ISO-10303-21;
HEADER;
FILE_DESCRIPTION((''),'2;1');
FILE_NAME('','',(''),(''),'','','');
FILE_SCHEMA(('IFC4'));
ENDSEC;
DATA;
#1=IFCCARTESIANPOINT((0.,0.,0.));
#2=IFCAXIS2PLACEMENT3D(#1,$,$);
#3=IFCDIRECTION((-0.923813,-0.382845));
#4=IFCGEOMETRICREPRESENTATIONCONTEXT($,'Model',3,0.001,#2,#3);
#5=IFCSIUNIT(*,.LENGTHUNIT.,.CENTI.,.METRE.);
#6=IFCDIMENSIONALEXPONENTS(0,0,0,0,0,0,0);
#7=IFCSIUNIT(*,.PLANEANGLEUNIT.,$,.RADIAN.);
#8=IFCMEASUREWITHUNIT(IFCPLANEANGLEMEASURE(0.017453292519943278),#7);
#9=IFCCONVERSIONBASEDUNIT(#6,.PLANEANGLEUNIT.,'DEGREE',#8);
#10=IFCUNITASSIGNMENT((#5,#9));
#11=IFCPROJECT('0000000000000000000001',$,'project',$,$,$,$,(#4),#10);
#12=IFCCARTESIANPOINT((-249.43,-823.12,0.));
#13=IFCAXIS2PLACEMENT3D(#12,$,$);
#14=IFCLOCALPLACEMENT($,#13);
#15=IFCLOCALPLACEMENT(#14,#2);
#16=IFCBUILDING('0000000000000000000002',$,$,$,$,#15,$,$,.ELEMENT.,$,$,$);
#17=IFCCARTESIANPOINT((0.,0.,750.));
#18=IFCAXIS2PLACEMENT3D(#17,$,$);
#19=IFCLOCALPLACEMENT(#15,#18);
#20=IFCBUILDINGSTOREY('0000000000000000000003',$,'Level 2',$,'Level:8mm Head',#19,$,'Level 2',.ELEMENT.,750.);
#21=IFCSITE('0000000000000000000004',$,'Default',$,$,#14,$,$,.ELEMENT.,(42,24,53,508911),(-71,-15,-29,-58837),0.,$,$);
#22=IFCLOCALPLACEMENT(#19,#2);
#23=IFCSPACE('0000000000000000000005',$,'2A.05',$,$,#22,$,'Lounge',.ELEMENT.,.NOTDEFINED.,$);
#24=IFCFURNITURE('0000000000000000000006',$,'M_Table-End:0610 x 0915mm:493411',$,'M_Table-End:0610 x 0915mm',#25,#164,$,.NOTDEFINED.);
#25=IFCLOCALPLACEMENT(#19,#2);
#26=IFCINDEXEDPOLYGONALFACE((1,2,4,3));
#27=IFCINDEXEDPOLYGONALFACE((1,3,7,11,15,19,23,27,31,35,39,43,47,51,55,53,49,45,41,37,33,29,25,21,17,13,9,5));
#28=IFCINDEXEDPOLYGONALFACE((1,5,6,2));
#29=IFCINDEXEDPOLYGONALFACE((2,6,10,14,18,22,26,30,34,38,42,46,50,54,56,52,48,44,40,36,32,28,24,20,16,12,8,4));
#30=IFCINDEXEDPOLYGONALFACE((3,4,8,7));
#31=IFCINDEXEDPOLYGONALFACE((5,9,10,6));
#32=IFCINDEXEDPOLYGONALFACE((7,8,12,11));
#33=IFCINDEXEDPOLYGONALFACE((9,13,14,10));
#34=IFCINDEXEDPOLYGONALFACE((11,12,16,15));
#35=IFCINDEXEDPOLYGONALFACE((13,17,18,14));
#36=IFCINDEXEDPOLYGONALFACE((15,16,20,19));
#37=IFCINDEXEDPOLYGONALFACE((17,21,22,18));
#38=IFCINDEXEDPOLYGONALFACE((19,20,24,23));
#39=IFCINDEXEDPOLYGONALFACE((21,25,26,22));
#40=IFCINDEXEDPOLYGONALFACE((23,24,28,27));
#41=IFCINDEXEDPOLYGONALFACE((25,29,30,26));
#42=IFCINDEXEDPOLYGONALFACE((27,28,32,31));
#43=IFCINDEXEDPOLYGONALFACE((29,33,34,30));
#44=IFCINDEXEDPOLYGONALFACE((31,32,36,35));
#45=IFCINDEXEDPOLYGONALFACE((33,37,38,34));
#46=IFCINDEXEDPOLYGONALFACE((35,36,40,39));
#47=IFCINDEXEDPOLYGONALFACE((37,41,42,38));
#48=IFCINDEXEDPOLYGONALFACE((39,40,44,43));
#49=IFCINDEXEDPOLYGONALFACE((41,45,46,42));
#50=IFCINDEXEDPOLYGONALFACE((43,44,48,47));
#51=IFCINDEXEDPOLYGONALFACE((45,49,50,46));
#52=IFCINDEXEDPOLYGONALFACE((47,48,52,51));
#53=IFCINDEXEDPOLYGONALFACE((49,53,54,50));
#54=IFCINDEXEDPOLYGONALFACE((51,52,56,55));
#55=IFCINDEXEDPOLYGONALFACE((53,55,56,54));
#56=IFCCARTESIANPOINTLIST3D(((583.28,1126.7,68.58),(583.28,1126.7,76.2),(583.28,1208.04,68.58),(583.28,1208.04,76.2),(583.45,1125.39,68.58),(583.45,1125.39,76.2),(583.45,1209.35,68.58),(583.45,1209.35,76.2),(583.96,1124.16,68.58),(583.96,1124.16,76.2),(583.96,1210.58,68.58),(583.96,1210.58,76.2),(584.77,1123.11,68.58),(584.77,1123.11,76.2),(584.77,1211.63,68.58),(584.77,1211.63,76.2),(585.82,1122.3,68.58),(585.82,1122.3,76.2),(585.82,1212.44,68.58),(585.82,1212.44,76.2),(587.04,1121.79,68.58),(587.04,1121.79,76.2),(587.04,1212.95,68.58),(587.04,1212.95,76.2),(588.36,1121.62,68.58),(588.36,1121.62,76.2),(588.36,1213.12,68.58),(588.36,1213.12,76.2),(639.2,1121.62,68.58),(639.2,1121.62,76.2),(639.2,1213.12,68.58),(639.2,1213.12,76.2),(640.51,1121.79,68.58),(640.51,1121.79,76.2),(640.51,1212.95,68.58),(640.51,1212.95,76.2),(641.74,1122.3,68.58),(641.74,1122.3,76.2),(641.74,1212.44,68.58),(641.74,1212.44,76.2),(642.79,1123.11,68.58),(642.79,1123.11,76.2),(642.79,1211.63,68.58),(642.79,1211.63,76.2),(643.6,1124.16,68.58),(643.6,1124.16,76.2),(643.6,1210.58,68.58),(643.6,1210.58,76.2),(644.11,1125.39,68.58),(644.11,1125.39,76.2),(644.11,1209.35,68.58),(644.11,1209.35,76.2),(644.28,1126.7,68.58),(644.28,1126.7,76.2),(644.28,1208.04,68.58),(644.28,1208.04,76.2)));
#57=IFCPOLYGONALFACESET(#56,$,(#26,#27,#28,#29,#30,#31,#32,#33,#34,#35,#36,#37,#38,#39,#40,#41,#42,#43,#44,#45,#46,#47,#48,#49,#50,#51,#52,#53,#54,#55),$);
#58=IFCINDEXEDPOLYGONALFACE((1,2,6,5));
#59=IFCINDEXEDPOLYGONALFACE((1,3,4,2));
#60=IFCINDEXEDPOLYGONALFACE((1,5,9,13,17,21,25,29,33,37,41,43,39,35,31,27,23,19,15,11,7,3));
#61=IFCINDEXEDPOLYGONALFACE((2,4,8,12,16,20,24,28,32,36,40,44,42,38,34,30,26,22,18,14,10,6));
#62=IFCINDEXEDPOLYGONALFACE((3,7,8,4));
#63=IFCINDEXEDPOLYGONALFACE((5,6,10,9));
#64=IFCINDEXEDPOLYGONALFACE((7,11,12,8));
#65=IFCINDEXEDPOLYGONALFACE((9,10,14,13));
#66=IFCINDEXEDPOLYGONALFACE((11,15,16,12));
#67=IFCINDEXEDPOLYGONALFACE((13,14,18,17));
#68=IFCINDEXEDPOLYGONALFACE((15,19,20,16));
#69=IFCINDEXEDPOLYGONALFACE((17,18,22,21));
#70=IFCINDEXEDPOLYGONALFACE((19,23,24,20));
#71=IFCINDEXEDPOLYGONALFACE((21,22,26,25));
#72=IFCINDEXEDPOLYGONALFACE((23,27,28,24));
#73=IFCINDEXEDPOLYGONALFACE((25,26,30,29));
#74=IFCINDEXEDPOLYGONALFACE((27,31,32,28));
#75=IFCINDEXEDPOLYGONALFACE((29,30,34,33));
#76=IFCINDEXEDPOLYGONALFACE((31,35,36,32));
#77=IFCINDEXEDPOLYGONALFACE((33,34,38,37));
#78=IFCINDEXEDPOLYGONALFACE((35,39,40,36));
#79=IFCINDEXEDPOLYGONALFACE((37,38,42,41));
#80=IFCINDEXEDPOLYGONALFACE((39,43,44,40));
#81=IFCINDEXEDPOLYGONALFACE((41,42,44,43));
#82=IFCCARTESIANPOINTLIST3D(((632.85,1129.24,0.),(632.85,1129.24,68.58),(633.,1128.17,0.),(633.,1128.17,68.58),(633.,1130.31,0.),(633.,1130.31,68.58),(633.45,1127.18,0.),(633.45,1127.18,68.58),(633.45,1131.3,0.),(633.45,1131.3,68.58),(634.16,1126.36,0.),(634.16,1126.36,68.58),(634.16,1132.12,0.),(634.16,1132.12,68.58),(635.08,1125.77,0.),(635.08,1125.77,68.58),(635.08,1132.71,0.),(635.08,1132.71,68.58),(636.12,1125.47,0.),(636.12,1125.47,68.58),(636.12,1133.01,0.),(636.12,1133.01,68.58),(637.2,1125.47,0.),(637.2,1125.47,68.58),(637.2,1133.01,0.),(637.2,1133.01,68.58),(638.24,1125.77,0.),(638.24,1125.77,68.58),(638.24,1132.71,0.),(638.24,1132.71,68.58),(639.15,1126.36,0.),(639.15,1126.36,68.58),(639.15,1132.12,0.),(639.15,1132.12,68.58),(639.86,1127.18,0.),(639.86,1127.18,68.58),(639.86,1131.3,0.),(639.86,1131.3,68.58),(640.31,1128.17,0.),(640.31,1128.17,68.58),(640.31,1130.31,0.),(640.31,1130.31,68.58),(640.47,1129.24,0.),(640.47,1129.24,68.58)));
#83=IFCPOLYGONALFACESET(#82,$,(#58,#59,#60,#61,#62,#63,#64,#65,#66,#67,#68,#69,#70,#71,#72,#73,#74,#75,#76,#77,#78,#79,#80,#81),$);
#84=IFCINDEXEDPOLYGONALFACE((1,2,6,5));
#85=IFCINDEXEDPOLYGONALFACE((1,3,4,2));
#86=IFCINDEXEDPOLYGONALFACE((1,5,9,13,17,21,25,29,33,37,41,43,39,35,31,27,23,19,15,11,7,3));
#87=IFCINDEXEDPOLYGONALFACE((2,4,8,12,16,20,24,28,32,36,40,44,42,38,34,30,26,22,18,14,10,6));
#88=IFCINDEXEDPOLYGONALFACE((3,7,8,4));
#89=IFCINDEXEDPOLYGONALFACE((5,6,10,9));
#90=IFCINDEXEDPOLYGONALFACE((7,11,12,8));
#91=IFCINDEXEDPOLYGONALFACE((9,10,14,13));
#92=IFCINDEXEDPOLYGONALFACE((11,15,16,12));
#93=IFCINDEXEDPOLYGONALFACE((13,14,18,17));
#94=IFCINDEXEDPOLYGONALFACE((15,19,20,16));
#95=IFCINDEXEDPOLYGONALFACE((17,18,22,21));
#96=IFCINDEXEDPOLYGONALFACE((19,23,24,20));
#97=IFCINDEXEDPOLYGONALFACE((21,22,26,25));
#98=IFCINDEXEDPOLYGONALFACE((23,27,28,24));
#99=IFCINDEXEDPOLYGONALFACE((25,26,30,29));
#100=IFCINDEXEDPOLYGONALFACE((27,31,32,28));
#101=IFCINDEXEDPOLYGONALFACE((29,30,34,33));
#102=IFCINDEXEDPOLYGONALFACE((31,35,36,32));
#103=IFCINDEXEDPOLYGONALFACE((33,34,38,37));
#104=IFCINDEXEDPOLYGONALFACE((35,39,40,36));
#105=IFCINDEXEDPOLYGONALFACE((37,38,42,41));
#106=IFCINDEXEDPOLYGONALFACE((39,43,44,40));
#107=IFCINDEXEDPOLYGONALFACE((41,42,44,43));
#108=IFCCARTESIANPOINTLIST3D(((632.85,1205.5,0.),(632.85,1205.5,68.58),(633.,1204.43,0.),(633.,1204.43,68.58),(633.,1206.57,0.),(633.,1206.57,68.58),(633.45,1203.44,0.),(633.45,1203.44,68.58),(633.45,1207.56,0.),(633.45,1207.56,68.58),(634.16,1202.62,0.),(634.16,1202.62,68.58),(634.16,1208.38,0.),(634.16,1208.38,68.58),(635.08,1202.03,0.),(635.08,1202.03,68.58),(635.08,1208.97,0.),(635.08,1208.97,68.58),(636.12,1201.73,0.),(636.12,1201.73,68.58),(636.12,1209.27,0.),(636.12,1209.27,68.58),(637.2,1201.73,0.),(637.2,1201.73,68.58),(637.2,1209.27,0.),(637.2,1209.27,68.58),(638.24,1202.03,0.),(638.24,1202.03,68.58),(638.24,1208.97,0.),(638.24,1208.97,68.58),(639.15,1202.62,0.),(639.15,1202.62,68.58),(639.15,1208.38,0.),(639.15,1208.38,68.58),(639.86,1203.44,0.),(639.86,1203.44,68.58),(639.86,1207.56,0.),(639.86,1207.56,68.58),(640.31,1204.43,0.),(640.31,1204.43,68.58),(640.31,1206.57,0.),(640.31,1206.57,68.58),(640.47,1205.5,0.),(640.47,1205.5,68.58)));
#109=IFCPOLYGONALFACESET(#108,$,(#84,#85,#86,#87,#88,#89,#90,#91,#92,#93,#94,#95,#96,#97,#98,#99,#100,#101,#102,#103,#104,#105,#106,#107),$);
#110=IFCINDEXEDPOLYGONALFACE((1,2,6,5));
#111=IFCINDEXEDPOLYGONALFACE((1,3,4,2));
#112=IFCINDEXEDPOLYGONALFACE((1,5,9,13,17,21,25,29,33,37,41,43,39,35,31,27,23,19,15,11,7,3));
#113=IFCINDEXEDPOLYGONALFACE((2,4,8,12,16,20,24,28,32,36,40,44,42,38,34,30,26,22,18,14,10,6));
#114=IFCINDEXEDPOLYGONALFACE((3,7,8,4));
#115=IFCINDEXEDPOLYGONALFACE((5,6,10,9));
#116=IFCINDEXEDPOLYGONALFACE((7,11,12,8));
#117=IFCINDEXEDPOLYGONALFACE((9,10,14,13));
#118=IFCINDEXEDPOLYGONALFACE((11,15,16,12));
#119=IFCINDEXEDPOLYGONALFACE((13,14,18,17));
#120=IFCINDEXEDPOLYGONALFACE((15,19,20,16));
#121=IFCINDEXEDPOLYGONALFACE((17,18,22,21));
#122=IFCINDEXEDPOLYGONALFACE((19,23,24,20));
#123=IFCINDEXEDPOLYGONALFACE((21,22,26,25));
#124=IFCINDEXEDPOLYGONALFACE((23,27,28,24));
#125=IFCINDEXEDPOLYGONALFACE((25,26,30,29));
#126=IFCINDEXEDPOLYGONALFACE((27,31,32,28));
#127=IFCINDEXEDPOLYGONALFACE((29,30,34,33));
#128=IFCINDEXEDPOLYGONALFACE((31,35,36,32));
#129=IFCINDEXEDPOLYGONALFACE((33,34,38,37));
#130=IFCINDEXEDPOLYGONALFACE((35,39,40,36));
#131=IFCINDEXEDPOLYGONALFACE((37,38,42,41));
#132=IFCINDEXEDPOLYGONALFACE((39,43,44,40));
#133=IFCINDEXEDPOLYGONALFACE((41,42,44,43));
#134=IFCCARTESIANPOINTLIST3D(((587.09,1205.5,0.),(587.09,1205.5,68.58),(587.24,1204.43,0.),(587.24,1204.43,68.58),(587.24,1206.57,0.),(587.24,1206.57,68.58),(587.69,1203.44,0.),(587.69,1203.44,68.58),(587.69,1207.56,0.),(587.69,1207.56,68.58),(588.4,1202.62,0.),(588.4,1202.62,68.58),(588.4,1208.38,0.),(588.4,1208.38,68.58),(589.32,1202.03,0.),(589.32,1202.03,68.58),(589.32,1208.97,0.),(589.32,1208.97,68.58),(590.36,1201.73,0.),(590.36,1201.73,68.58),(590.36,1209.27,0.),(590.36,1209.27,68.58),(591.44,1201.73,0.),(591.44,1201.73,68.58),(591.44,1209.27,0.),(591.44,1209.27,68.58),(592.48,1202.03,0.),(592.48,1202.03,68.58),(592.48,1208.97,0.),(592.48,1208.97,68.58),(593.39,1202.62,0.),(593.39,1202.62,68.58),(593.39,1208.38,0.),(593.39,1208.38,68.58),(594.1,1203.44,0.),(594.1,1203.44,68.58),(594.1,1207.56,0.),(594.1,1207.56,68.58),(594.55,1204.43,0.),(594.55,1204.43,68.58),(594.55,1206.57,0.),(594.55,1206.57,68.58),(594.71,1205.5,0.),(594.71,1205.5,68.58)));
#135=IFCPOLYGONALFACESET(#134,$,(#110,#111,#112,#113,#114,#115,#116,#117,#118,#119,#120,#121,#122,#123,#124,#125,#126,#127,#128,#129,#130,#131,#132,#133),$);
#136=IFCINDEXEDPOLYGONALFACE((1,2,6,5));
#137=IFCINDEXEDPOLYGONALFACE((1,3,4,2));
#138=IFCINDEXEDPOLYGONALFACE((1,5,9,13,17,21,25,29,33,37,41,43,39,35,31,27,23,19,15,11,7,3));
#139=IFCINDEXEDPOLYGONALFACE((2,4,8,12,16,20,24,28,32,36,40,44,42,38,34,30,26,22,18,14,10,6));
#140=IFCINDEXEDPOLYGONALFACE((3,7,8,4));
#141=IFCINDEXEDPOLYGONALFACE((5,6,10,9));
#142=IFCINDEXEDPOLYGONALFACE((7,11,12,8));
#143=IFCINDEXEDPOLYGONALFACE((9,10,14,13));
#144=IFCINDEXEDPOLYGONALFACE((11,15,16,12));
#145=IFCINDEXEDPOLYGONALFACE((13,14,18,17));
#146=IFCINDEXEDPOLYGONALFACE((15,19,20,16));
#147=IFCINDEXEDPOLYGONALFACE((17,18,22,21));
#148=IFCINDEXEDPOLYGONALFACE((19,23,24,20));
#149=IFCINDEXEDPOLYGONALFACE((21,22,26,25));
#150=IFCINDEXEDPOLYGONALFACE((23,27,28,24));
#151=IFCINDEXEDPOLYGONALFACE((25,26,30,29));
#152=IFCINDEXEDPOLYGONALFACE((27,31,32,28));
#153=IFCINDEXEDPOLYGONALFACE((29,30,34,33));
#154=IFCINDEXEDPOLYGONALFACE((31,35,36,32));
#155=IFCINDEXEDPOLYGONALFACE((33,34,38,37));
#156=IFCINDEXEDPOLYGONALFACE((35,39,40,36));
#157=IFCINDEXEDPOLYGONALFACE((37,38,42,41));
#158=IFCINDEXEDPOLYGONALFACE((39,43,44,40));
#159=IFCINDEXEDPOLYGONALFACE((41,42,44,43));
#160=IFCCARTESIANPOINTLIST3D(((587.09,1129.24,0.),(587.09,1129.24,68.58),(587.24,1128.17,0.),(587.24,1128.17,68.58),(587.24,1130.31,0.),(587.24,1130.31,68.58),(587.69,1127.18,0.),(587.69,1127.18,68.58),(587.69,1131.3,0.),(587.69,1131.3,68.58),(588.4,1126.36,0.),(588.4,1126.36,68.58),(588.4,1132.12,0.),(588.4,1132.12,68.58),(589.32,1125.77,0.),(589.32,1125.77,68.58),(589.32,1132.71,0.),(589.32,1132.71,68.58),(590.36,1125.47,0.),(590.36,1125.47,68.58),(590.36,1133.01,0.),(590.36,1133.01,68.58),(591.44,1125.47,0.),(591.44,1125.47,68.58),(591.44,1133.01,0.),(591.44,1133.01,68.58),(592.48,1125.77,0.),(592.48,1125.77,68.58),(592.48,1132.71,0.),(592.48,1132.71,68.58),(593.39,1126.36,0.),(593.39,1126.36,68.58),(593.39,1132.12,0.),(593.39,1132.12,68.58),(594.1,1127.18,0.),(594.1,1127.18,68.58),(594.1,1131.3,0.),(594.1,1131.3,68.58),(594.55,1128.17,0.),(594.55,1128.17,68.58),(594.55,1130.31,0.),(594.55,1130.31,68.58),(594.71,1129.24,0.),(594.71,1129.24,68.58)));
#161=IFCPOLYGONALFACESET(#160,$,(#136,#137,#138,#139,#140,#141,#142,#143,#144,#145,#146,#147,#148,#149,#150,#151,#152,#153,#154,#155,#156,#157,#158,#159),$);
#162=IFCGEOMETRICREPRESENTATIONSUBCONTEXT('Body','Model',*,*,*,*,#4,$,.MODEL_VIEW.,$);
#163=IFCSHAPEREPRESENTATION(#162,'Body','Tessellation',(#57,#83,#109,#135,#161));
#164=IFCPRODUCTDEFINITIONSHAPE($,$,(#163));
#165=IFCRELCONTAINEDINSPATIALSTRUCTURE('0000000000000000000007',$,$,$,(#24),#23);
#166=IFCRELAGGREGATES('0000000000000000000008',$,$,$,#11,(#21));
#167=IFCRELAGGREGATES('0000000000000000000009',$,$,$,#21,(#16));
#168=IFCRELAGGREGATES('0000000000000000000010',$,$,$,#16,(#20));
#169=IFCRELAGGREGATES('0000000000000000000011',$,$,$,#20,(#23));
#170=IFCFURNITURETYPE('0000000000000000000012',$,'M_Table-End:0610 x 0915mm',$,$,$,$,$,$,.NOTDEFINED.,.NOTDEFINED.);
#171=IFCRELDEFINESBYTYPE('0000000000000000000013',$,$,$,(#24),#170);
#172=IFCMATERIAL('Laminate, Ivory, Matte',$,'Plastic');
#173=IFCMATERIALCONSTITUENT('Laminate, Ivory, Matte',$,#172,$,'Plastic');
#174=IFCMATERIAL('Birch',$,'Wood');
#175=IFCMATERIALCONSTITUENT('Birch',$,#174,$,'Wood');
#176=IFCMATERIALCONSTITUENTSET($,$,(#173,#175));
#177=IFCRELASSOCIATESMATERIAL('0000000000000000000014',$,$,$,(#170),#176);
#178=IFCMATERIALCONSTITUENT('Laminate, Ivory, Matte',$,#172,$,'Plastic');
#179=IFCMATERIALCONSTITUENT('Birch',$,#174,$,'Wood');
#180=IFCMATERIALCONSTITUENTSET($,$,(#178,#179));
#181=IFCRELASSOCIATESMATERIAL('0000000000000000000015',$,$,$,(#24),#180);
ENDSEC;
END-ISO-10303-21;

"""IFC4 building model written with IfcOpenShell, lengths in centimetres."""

from ifc_helpers import new_model, entity, si_unit, converted_unit, direction, frame, origin, place, context, subcontext, project, spatial, line, arc, indexed_curve, outline, extrude, source, transform, mapped, material, constituent, constituent_set, type_object, type_shapes, element, save


model = new_model("IFC4")

# Units and contexts
model_context = context("Model", 3, precision=0.001, world=origin(), true_north=direction((-0.923813, -0.382845)))
body_context = subcontext(model_context, "Body", "Model", "MODEL_VIEW")
ifc_project = project(units=[si_unit("LENGTHUNIT", "METRE", prefix="CENTI"), converted_unit("PLANEANGLEUNIT", "DEGREE", entity("IfcPlaneAngleMeasure", 0.017453292519943278), si_unit("PLANEANGLEUNIT", "RADIAN"), dimensions=[0, 0, 0, 0, 0, 0, 0])], contexts=[model_context])

# Site, building, storey
site_placement = place(None, frame((-249.43, -823.12, 0.0)))
site = spatial("IfcSite", under=ifc_project, at=site_placement, Name="Default", CompositionType="ELEMENT", RefLatitude=(42, 24, 53, 508911), RefLongitude=(-71, -15, -29, -58837), RefElevation=0.0)
building_placement = place(site_placement, origin())
building = spatial("IfcBuilding", under=site, at=building_placement, CompositionType="ELEMENT")
storey_placement = place(building_placement, frame((0.0, 0.0, 750.0)))
storey = spatial("IfcBuildingStorey", under=building, at=storey_placement, Name="Level 2", ObjectType="Level:8mm Head", LongName="Level 2", CompositionType="ELEMENT", Elevation=750.0)

# Shared definitions
space_1_placement = place(storey_placement, origin())
space_1 = spatial("IfcSpace", under=storey, at=space_1_placement, Name="2A.05", LongName="Lounge", CompositionType="ELEMENT", PredefinedType="NOTDEFINED")

# Furniture
ifc_material_1 = material(Name="Laminate, Ivory, Matte", Category="Plastic")
ifc_constituent_1 = constituent(ifc_material_1, Name="Laminate, Ivory, Matte", Category="Plastic")
ifc_material_2 = material(Name="Birch", Category="Wood")
ifc_constituent_2 = constituent(ifc_material_2, Name="Birch", Category="Wood")
ifc_constituent_set_1 = constituent_set(constituents=[ifc_constituent_1, ifc_constituent_2])
ifc_constituent_3 = constituent(ifc_material_1, Name="Laminate, Ivory, Matte", Category="Plastic")
ifc_constituent_4 = constituent(ifc_material_2, Name="Birch", Category="Wood")
ifc_constituent_set_2 = constituent_set(constituents=[ifc_constituent_3, ifc_constituent_4])
furniture_type_1 = type_object("IfcFurnitureType", Name="M_Table-End:0610 x 0915mm", AssemblyPlace="NOTDEFINED", PredefinedType="NOTDEFINED", material=ifc_constituent_set_2)
shared_shape_1 = source(origin(), body_context, "Body", "SweptSolid", [
    extrude(outline(indexed_curve([(25.42, -45.75), (29.01, -44.26), (30.5, -40.67), (30.5, 40.67), (29.01, 44.26), (25.42, 45.75), (-25.42, 45.75), (-29.01, 44.26), (-30.5, 40.67), (-30.5, -40.67), (-29.01, -44.26), (-25.42, -45.75)], segments=[arc(1, 2, 3), line(3, 4), arc(4, 5, 6), line(6, 7), arc(7, 8, 9), line(9, 10), arc(10, 11, 12), line(12, 1)], self_intersect=False)), frame((30.87, 15.24, -381.42)), (0.0, 0.0, 1.0), 7.62),
    extrude(outline(indexed_curve([(-3.81, 0.0), (0.0, -3.81), (3.81, 0.0), (0.0, 3.81)], segments=[arc(1, 2, 3), arc(3, 4, 1)], self_intersect=False)), frame((53.75, -22.89, -450.0)), (0.0, 0.0, 1.0), 68.58),
    extrude(outline(indexed_curve([(-3.81, 0.0), (0.0, -3.81), (3.81, 0.0), (0.0, 3.81)], segments=[arc(1, 2, 3), arc(3, 4, 1)], self_intersect=False)), frame((53.75, 53.37, -450.0)), (0.0, 0.0, 1.0), 68.58),
    extrude(outline(indexed_curve([(-3.81, 0.0), (0.0, -3.81), (3.81, 0.0), (0.0, 3.81)], segments=[arc(1, 2, 3), arc(3, 4, 1)], self_intersect=False)), frame((7.99, 53.37, -450.0)), (0.0, 0.0, 1.0), 68.58),
    extrude(outline(indexed_curve([(-3.81, 0.0), (0.0, -3.81), (3.81, 0.0), (0.0, 3.81)], segments=[arc(1, 2, 3), arc(3, 4, 1)], self_intersect=False)), frame((7.99, -22.89, -450.0)), (0.0, 0.0, 1.0), 68.58),
])
type_shapes(furniture_type_1, [shared_shape_1])
furniture_1_placement = place(space_1_placement, frame((582.9, 1152.13, 450.0)))
element("IfcFurniture", 1, at=furniture_1_placement, inside=space_1, type_object=furniture_type_1, material=ifc_constituent_set_1, Name="M_Table-End:0610 x 0915mm:493411", ObjectType="M_Table-End:0610 x 0915mm", PredefinedType="NOTDEFINED", context=body_context, shape_type="MappedRepresentation", body=[
    mapped(shared_shape_1, transform((0.0, 0.0, 0.0), scale=1.0)),
])

save(model, "model.ifc")
